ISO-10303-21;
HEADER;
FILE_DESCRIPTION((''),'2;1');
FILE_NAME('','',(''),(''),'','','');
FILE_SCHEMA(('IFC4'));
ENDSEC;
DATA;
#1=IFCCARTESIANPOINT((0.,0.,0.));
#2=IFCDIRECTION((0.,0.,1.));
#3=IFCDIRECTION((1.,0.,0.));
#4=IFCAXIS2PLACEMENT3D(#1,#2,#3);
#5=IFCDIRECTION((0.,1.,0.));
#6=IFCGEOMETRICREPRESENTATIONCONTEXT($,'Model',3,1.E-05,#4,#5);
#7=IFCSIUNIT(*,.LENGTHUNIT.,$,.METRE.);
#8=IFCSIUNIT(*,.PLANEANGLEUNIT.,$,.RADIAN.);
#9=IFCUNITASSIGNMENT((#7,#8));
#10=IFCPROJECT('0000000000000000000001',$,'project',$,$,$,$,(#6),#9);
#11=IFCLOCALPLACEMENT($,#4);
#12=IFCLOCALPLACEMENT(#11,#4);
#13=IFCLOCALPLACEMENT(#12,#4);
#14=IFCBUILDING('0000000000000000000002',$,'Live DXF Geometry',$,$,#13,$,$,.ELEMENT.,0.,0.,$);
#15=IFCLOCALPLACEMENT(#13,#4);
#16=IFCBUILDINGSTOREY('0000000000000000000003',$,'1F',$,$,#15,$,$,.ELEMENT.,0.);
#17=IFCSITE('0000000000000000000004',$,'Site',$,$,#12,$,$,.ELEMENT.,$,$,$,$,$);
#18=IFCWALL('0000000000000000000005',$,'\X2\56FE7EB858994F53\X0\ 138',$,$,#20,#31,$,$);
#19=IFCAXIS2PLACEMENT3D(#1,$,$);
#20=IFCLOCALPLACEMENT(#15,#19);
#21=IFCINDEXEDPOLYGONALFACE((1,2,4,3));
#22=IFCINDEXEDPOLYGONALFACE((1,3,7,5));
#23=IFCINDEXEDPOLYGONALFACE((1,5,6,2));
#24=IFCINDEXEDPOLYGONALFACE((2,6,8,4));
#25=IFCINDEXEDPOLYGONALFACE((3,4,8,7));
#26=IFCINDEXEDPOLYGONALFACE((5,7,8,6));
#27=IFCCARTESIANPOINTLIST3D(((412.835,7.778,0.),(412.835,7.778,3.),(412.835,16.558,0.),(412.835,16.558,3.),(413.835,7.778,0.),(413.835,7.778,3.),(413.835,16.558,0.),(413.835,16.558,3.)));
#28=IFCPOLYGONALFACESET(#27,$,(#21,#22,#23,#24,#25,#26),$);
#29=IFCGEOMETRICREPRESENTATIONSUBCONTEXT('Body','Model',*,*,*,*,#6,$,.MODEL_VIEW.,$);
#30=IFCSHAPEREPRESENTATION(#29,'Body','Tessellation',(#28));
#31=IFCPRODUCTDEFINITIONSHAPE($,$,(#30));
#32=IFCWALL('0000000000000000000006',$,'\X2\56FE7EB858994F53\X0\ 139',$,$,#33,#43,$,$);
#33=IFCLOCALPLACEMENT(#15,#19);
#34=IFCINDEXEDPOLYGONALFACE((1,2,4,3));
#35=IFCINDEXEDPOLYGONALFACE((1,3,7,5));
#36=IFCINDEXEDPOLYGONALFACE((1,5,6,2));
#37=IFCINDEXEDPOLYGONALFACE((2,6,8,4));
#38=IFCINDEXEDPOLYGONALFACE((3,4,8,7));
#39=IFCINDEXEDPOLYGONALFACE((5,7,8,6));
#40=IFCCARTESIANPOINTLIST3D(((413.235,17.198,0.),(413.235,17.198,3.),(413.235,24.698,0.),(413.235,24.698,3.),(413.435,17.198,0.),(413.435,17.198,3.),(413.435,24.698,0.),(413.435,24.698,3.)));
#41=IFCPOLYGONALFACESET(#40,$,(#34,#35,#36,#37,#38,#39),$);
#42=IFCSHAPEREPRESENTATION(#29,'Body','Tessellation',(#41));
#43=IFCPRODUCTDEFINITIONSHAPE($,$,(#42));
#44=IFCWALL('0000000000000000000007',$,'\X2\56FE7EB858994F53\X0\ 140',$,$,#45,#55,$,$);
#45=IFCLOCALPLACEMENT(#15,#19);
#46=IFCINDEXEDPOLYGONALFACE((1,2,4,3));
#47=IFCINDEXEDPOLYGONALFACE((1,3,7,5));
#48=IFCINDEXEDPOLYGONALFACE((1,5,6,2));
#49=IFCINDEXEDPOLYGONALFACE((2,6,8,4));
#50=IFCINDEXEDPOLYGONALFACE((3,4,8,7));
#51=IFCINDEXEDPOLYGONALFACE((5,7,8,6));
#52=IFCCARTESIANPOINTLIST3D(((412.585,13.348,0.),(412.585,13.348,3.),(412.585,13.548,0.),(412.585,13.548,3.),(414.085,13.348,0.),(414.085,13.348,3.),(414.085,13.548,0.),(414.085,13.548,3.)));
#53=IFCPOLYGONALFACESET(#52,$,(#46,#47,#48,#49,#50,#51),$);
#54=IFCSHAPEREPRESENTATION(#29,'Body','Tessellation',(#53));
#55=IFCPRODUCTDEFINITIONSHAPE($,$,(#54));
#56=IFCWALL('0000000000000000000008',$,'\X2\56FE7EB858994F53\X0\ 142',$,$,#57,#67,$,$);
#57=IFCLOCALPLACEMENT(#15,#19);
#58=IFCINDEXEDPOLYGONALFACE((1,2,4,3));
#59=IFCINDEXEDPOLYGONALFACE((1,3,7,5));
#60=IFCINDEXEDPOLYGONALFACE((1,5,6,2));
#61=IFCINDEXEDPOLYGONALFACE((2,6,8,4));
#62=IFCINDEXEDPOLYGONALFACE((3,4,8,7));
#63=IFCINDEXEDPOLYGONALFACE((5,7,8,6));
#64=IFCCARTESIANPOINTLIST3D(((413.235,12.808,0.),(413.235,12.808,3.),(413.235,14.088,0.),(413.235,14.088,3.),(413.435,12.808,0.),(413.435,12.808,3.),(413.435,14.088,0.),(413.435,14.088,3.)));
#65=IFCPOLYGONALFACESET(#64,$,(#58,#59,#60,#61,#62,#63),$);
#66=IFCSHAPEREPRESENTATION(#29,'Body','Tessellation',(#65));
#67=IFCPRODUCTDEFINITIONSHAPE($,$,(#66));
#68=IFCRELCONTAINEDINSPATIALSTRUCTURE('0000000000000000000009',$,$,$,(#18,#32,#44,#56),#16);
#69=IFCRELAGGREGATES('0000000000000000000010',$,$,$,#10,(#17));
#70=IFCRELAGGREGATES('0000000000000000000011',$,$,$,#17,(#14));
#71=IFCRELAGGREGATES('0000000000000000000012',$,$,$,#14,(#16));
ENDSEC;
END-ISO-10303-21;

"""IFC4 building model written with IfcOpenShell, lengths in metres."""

from ifc_helpers import new_model, si_unit, direction, frame, frame_2d, origin_with_axes, place, context, subcontext, project, spatial, rectangle, extrude, element, save


model = new_model("IFC4")

# Units and contexts
model_context = context("Model", 3, precision=1e-05, world=origin_with_axes(), true_north=direction((0.0, 1.0, 0.0)))
body_context = subcontext(model_context, "Body", "Model", "MODEL_VIEW")
ifc_project = project(units=[si_unit("LENGTHUNIT", "METRE"), si_unit("PLANEANGLEUNIT", "RADIAN")], contexts=[model_context])

# Site, building, storey
placement = place(None, origin_with_axes())
site_placement = place(placement, origin_with_axes())
site = spatial("IfcSite", under=ifc_project, at=site_placement, Name="Site", CompositionType="ELEMENT")
building_placement = place(site_placement, origin_with_axes())
building = spatial("IfcBuilding", under=site, at=building_placement, Name="Live DXF Geometry", CompositionType="ELEMENT", ElevationOfRefHeight=0.0, ElevationOfTerrain=0.0)
storey_placement = place(building_placement, origin_with_axes())
storey = spatial("IfcBuildingStorey", under=building, at=storey_placement, Name="1F", CompositionType="ELEMENT", Elevation=0.0)

# Walls
wall_1_placement = place(storey_placement, frame((413.335, 12.168, 0.0), z_axis=(0.0, 0.0, 1.0), x_axis=(1.0, 0.0, 0.0)))
element("IfcWall", 1, at=wall_1_placement, inside=storey, Name="图纸墙体 138", context=body_context, shape_type="SweptSolid", body=[
    extrude(rectangle(XDim=1.0, YDim=8.78, at=frame_2d((0.0, 0.0), x_axis=(1.0, 0.0, 0.0))), frame((0.0, 0.0, 0.0), z_axis=(0.0, 0.0, 1.0)), (0.0, 0.0, 1.0), 3.0),
])
wall_2_placement = place(storey_placement, frame((413.335, 20.948, 0.0), z_axis=(0.0, 0.0, 1.0), x_axis=(0.0, -1.0, 0.0)))
element("IfcWall", 2, at=wall_2_placement, inside=storey, Name="图纸墙体 139", context=body_context, shape_type="SweptSolid", body=[
    extrude(rectangle(XDim=7.5, YDim=0.2, at=frame_2d((0.0, 0.0), x_axis=(1.0, 0.0, 0.0))), frame((0.0, 0.0, 0.0), z_axis=(0.0, 0.0, 1.0)), (0.0, 0.0, 1.0), 3.0),
])
wall_3_placement = place(storey_placement, frame((413.335, 13.448, 0.0), z_axis=(0.0, 0.0, 1.0), x_axis=(1.0, 0.0, 0.0)))
element("IfcWall", 3, at=wall_3_placement, inside=storey, Name="图纸墙体 140", context=body_context, shape_type="SweptSolid", body=[
    extrude(rectangle(XDim=1.5, YDim=0.2, at=frame_2d((0.0, 0.0), x_axis=(1.0, 0.0, 0.0))), frame((0.0, 0.0, 0.0), z_axis=(0.0, 0.0, 1.0)), (0.0, 0.0, 1.0), 3.0),
])
wall_4_placement = place(storey_placement, frame((413.335, 13.448, 0.0), z_axis=(0.0, 0.0, 1.0), x_axis=(0.0, -1.0, 0.0)))
element("IfcWall", 4, at=wall_4_placement, inside=storey, Name="图纸墙体 142", context=body_context, shape_type="SweptSolid", body=[
    extrude(rectangle(XDim=1.28, YDim=0.2, at=frame_2d((0.0, 0.0), x_axis=(1.0, 0.0, 0.0))), frame((0.0, 0.0, 0.0), z_axis=(0.0, 0.0, 1.0)), (0.0, 0.0, 1.0), 3.0),
])

save(model, "model.ifc")
